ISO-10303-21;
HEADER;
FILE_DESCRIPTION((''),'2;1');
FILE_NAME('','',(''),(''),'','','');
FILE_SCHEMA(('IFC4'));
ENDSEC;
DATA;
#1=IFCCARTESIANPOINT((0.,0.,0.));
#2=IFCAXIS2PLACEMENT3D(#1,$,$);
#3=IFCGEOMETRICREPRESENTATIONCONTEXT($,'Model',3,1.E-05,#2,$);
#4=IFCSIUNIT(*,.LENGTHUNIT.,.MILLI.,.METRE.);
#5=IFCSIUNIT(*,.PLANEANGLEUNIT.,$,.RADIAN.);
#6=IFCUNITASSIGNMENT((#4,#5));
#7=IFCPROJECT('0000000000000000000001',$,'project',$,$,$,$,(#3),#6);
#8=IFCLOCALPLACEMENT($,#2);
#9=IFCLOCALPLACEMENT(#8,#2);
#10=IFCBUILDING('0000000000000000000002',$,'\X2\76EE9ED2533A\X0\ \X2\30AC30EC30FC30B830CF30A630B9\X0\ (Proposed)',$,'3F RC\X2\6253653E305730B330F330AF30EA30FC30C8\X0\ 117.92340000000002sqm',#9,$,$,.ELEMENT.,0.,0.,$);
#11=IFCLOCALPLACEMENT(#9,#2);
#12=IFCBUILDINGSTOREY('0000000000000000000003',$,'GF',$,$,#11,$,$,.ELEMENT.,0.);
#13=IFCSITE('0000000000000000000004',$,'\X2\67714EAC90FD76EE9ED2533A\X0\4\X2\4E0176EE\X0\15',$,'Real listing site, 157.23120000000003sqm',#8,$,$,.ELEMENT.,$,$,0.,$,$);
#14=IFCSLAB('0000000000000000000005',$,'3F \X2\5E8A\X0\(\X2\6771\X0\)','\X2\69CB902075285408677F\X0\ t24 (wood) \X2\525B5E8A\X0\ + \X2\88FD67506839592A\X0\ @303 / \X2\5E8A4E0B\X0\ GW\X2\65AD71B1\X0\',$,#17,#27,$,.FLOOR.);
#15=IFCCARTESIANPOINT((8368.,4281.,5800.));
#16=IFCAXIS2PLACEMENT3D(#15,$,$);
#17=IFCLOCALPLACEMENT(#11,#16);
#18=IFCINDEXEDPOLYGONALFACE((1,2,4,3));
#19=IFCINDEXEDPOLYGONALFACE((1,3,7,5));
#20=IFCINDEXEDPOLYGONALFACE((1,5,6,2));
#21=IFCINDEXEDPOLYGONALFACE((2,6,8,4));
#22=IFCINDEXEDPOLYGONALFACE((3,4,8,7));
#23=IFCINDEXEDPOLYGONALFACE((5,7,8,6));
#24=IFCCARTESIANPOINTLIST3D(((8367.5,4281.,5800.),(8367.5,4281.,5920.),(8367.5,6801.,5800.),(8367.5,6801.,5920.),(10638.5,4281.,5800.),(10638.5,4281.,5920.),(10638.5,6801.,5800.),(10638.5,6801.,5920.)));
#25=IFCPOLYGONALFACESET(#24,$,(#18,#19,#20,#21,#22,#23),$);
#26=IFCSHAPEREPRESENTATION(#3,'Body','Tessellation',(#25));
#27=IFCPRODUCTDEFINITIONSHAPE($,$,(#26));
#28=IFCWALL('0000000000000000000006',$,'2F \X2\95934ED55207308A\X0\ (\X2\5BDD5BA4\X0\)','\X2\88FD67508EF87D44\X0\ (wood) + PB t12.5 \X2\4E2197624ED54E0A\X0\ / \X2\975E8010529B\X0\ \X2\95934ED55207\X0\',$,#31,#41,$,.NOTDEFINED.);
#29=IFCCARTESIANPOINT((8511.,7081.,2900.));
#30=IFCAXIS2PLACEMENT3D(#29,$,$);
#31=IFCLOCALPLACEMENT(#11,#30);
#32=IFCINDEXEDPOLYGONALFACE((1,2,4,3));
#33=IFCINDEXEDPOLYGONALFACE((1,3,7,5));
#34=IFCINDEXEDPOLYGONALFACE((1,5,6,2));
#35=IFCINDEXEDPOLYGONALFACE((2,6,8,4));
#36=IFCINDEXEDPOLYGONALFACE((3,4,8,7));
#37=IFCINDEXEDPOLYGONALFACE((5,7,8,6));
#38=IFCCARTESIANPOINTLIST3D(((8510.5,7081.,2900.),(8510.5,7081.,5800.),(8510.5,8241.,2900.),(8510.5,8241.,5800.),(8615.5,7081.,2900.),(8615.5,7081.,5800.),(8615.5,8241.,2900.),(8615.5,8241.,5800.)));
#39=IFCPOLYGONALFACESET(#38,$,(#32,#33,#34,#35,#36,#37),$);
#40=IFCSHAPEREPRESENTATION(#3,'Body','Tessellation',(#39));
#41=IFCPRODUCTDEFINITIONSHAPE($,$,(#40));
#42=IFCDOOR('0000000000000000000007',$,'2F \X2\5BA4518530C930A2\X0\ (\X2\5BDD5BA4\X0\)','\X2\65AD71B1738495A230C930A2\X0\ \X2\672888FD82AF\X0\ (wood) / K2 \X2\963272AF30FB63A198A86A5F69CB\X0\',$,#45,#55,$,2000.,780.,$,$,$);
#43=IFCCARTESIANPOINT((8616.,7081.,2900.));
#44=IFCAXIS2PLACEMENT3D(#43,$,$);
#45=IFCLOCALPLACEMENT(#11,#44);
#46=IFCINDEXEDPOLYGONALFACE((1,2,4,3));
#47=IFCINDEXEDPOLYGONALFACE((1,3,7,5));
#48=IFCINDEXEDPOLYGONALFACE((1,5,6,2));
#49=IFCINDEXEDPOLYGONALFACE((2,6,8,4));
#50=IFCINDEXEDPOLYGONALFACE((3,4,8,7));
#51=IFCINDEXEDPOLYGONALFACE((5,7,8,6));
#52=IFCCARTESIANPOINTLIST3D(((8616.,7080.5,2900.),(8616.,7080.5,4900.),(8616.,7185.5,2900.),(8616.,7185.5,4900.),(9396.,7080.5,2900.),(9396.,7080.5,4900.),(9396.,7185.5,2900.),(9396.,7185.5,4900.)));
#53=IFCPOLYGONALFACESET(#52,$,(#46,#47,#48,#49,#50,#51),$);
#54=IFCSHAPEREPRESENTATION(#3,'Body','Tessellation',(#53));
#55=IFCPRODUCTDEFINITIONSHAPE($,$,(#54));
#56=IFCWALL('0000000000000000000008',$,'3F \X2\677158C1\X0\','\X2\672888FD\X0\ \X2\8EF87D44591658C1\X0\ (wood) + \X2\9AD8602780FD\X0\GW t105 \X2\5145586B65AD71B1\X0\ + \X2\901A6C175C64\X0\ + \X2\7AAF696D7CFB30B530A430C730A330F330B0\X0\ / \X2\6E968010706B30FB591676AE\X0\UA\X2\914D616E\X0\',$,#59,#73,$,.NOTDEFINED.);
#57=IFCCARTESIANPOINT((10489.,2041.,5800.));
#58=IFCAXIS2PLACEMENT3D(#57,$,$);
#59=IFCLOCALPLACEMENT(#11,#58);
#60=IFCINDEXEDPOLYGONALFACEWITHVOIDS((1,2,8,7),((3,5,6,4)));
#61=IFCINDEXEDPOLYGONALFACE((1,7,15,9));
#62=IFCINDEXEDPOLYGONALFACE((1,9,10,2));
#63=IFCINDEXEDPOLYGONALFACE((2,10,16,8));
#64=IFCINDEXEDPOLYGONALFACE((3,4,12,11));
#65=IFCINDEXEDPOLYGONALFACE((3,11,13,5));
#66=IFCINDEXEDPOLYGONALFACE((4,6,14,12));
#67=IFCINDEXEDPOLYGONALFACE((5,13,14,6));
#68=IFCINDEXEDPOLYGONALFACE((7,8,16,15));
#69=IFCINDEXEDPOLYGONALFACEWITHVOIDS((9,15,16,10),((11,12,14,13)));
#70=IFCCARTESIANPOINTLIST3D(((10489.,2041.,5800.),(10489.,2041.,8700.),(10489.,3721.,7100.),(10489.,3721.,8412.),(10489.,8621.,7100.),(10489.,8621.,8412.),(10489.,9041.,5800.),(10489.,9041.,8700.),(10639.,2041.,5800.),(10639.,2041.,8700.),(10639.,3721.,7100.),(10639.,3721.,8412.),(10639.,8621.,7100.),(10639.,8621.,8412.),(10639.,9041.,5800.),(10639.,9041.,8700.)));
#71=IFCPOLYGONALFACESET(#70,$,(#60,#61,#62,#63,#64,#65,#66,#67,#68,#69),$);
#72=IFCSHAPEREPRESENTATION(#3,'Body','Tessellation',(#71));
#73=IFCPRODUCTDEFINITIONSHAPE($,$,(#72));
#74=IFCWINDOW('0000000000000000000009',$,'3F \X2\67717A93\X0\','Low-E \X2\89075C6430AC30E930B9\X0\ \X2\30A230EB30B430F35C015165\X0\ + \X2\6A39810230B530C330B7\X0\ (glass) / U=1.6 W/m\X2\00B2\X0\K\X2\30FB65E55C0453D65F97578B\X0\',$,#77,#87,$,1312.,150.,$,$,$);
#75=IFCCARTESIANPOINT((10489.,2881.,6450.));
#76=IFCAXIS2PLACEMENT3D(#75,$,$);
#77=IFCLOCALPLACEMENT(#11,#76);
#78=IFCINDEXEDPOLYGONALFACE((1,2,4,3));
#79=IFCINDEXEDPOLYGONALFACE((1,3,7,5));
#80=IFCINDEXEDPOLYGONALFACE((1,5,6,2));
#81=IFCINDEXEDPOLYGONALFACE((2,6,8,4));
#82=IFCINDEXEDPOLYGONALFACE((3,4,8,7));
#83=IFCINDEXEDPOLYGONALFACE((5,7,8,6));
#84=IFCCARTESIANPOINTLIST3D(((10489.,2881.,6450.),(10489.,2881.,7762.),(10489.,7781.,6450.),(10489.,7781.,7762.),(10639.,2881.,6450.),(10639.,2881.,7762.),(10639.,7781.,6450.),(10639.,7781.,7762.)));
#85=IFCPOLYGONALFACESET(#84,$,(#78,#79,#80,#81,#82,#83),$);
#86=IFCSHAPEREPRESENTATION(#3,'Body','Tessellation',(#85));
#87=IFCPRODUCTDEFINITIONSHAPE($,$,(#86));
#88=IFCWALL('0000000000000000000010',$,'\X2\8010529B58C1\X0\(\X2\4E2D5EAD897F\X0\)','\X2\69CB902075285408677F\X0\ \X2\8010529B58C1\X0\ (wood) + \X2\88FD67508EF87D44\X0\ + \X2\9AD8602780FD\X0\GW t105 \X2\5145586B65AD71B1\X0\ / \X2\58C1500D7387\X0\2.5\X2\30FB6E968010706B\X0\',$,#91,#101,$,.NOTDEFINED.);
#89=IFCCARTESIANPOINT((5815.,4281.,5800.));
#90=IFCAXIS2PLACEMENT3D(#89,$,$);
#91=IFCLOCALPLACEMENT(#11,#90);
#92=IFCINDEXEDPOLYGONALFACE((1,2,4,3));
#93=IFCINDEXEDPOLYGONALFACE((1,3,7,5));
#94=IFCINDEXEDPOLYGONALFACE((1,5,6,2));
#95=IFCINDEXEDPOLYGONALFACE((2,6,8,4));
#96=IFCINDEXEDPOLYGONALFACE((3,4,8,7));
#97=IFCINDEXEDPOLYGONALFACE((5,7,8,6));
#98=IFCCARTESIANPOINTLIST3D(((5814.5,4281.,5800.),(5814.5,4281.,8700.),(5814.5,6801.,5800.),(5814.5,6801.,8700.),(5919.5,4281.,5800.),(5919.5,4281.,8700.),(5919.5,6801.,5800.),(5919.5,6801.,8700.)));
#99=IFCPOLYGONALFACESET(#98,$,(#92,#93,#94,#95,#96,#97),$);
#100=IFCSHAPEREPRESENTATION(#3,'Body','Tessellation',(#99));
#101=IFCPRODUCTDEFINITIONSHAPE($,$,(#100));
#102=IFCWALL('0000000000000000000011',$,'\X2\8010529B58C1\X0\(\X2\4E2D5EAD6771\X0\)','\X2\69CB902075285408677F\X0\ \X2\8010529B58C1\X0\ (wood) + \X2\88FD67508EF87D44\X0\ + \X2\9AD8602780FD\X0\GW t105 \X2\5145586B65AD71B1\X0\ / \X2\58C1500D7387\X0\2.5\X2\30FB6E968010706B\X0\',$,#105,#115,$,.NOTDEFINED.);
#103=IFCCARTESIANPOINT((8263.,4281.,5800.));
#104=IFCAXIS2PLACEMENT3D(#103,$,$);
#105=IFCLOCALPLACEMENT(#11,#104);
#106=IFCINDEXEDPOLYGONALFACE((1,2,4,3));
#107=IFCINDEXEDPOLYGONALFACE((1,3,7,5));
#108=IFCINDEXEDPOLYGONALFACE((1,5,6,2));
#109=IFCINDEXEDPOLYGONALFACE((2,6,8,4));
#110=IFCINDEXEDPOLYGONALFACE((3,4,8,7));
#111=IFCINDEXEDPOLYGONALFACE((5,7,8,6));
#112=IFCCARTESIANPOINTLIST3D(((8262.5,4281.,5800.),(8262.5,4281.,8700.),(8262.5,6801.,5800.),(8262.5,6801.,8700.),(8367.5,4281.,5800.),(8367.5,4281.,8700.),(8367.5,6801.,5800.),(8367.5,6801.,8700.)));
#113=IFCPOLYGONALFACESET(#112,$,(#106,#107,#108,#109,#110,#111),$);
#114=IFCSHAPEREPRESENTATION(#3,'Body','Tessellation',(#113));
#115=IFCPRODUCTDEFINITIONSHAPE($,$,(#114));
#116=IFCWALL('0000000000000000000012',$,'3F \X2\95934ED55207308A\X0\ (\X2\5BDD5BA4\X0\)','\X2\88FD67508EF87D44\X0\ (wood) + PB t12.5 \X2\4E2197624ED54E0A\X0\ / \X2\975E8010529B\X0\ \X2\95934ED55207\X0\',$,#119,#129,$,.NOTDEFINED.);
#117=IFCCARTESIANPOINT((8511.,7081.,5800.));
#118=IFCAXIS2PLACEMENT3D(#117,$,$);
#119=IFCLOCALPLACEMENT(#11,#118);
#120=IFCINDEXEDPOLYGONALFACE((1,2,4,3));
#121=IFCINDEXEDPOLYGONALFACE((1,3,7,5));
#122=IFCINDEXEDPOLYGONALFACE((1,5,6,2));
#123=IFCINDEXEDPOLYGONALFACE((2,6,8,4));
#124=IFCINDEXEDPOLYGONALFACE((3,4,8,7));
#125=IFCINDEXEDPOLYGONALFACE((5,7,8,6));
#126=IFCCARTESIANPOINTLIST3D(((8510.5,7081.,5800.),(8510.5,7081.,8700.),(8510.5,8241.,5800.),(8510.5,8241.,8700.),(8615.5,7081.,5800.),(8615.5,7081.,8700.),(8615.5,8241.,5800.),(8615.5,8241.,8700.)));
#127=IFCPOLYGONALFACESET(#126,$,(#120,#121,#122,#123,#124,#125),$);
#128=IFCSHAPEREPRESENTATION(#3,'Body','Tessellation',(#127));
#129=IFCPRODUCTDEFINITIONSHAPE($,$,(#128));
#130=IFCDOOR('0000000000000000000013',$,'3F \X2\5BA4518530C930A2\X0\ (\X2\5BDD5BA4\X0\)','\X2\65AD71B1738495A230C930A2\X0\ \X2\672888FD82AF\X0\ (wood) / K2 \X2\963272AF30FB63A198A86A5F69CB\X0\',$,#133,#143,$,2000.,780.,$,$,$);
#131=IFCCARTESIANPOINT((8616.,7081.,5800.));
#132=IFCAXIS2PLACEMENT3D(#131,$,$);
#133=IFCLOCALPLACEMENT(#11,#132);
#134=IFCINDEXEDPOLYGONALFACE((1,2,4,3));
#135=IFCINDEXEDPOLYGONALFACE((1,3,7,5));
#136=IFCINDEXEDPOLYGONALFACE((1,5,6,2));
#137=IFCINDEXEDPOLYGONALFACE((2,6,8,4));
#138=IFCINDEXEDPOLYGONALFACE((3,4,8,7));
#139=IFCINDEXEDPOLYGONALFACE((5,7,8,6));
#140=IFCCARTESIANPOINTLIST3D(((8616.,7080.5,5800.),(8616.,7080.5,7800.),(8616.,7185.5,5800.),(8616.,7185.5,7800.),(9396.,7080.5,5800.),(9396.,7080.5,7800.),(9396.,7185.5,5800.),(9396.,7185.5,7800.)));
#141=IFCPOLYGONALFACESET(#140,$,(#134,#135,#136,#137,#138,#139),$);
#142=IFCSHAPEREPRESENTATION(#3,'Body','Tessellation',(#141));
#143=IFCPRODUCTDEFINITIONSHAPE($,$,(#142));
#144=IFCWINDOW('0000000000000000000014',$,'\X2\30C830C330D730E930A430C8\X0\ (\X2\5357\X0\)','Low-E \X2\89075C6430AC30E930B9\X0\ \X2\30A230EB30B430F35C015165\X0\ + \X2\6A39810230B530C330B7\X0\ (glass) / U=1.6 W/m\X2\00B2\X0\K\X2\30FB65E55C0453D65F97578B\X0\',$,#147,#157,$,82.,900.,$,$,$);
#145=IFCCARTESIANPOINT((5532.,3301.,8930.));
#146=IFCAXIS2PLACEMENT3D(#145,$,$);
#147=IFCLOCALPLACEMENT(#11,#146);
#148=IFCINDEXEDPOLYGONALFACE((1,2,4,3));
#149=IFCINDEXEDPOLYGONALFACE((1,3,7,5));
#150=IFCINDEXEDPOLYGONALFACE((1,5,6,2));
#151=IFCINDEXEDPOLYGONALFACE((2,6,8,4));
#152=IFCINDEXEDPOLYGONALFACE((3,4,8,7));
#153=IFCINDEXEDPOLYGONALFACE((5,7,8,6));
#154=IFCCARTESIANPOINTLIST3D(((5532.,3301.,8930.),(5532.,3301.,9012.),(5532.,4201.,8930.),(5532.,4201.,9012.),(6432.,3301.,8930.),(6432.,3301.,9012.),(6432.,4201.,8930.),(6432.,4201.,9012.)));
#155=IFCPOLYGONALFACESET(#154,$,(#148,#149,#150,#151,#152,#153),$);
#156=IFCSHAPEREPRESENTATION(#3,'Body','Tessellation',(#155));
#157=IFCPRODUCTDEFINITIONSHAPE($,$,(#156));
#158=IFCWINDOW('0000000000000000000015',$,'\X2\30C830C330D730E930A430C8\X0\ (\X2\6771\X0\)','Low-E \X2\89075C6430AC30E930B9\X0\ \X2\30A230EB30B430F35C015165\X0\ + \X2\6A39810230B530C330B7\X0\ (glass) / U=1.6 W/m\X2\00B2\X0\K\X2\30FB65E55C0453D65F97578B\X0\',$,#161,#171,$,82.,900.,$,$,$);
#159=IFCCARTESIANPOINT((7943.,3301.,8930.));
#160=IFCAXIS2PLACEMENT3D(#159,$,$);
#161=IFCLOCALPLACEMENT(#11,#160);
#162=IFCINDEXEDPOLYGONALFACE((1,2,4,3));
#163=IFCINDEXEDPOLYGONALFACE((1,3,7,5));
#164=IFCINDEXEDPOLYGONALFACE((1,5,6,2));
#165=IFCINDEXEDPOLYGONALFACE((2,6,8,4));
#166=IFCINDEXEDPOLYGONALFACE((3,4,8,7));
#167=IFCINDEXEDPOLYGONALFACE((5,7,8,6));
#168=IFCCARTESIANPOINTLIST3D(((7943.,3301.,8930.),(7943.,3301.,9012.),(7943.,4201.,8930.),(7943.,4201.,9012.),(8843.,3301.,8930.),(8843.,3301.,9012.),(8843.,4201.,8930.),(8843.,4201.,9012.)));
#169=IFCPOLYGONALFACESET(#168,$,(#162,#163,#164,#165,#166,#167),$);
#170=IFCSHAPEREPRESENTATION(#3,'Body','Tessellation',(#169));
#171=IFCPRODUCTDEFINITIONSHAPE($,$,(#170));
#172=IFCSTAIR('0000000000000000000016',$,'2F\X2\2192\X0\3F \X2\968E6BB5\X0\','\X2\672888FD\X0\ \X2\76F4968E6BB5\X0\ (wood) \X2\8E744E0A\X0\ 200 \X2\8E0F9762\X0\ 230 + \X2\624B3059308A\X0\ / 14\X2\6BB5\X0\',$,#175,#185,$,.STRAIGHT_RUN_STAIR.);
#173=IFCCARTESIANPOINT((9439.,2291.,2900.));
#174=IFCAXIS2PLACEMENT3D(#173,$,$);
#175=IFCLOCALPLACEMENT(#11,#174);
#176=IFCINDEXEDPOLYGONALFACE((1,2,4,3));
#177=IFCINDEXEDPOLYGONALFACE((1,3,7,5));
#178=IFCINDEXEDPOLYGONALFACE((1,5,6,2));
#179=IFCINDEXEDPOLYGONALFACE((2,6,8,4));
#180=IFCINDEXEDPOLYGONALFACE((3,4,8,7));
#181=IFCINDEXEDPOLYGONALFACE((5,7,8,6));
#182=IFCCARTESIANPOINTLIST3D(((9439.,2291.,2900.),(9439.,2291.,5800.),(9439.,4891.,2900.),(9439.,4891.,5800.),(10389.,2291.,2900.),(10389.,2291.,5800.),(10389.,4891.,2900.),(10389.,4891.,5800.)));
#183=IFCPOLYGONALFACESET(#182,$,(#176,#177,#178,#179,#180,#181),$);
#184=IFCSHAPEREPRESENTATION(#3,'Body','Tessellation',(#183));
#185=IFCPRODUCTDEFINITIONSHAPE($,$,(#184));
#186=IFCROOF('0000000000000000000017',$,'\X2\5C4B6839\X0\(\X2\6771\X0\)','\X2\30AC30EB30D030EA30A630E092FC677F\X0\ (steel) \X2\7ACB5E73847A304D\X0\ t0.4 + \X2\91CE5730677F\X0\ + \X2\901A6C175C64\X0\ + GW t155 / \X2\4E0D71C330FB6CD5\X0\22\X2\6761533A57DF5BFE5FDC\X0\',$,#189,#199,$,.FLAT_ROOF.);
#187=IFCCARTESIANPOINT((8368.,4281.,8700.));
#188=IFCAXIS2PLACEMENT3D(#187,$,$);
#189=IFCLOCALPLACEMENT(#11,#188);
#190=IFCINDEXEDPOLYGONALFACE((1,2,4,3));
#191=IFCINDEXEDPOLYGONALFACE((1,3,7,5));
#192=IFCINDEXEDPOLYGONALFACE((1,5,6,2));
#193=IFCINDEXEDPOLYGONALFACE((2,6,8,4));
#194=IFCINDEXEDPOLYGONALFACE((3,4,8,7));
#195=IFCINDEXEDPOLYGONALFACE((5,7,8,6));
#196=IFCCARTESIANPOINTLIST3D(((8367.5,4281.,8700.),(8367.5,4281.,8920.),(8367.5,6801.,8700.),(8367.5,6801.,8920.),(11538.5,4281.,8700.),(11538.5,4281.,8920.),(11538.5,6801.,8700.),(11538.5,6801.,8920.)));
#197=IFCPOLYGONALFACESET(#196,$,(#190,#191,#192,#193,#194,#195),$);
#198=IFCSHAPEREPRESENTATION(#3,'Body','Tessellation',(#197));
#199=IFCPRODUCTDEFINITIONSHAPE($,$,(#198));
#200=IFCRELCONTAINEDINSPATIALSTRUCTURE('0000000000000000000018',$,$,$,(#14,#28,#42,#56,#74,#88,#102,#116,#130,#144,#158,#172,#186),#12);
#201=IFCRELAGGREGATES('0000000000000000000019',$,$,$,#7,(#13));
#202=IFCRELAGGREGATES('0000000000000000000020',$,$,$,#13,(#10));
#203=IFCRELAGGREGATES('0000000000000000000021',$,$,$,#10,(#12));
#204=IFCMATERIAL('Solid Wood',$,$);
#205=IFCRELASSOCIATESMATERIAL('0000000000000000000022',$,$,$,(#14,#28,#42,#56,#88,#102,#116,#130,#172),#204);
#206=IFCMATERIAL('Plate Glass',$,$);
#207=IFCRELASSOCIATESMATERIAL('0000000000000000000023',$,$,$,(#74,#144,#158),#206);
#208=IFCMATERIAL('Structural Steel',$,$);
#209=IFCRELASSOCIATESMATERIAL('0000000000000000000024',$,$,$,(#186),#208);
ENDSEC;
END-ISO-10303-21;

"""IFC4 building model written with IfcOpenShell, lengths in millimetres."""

from ifc_helpers import new_model, si_unit, frame, frame_2d, origin, place, context, project, spatial, rectangle, extrude, material, element, fill, save


model = new_model("IFC4")

# Units and contexts
model_context = context("Model", 3, precision=1e-05, world=origin())
ifc_project = project(units=[si_unit("LENGTHUNIT", "METRE", prefix="MILLI"), si_unit("PLANEANGLEUNIT", "RADIAN")], contexts=[model_context])

# Site, building, storey
site_placement = place(None, origin())
site = spatial("IfcSite", under=ifc_project, at=site_placement, Name="東京都目黒区4丁目15", ObjectType="Real listing site, 157.23120000000003sqm", CompositionType="ELEMENT", RefElevation=0.0)
building_placement = place(site_placement, origin())
building = spatial("IfcBuilding", under=site, at=building_placement, Name="目黒区 ガレージハウス (Proposed)", ObjectType="3F RC打放しコンクリート 117.92340000000002sqm", CompositionType="ELEMENT", ElevationOfRefHeight=0.0, ElevationOfTerrain=0.0)
storey_placement = place(building_placement, origin())
storey = spatial("IfcBuildingStorey", under=building, at=storey_placement, Name="GF", CompositionType="ELEMENT", Elevation=0.0)

# Slab
ifc_material_1 = material(Name="Solid Wood")
slab_placement = place(storey_placement, frame((8368.0, 4281.0, 5800.0)))
element("IfcSlab", 1, at=slab_placement, inside=storey, material=ifc_material_1, Name="3F 床(東)", Description="構造用合板 t24 (wood) 剛床 + 製材根太 @303 / 床下 GW断熱", PredefinedType="FLOOR", context=model_context, shape_type="SweptSolid", body=[
    extrude(rectangle(XDim=2271.0, YDim=2520.0, at=frame_2d((1135.0, 1260.0))), frame((8368.0, 4281.0, 5800.0)), (0.0, 0.0, 1.0), 120.0),
])

# Wall
wall_1_placement = place(storey_placement, frame((8511.0, 7081.0, 2900.0)))
element("IfcWall", 2, at=wall_1_placement, inside=storey, material=ifc_material_1, Name="2F 間仕切り (寝室)", Description="製材軸組 (wood) + PB t12.5 両面仕上 / 非耐力 間仕切", PredefinedType="NOTDEFINED", context=model_context, shape_type="SweptSolid", body=[
    extrude(rectangle(XDim=105.0, YDim=1160.0, at=frame_2d((52.0, 580.0))), frame((8511.0, 7081.0, 2900.0)), (0.0, 0.0, 1.0), 2900.0),
])

# Door
door_1_placement = place(storey_placement, frame((8616.0, 7081.0, 2900.0)))
element("IfcDoor", 3, at=door_1_placement, inside=storey, material=ifc_material_1, Name="2F 室内ドア (寝室)", Description="断熱玄関ドア 木製芯 (wood) / K2 防犯・採風機構", OverallHeight=2000.0, OverallWidth=780.0, context=model_context, shape_type="SweptSolid", body=[
    extrude(rectangle(XDim=780.0, YDim=105.0, at=frame_2d((390.0, 52.0))), frame((8616.0, 7081.0, 2900.0)), (0.0, 0.0, 1.0), 2000.0),
])

# Wall, opening, window
wall_2_placement = place(storey_placement, frame((10489.0, 2041.0, 5800.0)))
wall_2 = element("IfcWall", 4, at=wall_2_placement, inside=storey, material=ifc_material_1, Name="3F 東壁", Description="木製 軸組外壁 (wood) + 高性能GW t105 充填断熱 + 通気層 + 窯業系サイディング / 準耐火・外皮UA配慮", PredefinedType="NOTDEFINED", context=model_context, shape_type="SweptSolid", body=[
    extrude(rectangle(XDim=150.0, YDim=7000.0, at=frame_2d((75.0, 3500.0))), frame((10489.0, 2041.0, 5800.0)), (0.0, 0.0, 1.0), 2900.0),
])
opening_1_placement = place(storey_placement, frame((10489.0, 2881.0, 6450.0)))
opening_1 = element("IfcOpeningElement", 5, at=opening_1_placement, cuts=wall_2, PredefinedType="NOTDEFINED", context=model_context, shape_type="SweptSolid", body=[
    extrude(rectangle(XDim=150.0, YDim=4900.0, at=frame_2d((75.0, 2450.0))), frame((10489.0, 2881.0, 6450.0)), (0.0, 0.0, 1.0), 1312.0),
])
ifc_material_2 = material(Name="Plate Glass")
window_1_placement = place(storey_placement, frame((10489.0, 2881.0, 6450.0)))
window_1 = element("IfcWindow", 6, at=window_1_placement, inside=storey, material=ifc_material_2, Name="3F 東窓", Description="Low-E 複層ガラス アルゴン封入 + 樹脂サッシ (glass) / U=1.6 W/m²K・日射取得型", OverallHeight=1312.0, OverallWidth=150.0, context=model_context, shape_type="SweptSolid", body=[
    extrude(rectangle(XDim=150.0, YDim=4900.0, at=frame_2d((75.0, 2450.0))), frame((10489.0, 2881.0, 6450.0)), (0.0, 0.0, 1.0), 1312.0),
])
fill(opening_1, window_1)

# Walls
wall_3_placement = place(storey_placement, frame((5815.0, 4281.0, 5800.0)))
element("IfcWall", 7, at=wall_3_placement, inside=storey, material=ifc_material_1, Name="耐力壁(中庭西)", Description="構造用合板 耐力壁 (wood) + 製材軸組 + 高性能GW t105 充填断熱 / 壁倍率2.5・準耐火", PredefinedType="NOTDEFINED", context=model_context, shape_type="SweptSolid", body=[
    extrude(rectangle(XDim=105.0, YDim=2520.0, at=frame_2d((52.0, 1260.0))), frame((5815.0, 4281.0, 5800.0)), (0.0, 0.0, 1.0), 2900.0),
])
wall_4_placement = place(storey_placement, frame((8263.0, 4281.0, 5800.0)))
element("IfcWall", 8, at=wall_4_placement, inside=storey, material=ifc_material_1, Name="耐力壁(中庭東)", Description="構造用合板 耐力壁 (wood) + 製材軸組 + 高性能GW t105 充填断熱 / 壁倍率2.5・準耐火", PredefinedType="NOTDEFINED", context=model_context, shape_type="SweptSolid", body=[
    extrude(rectangle(XDim=105.0, YDim=2520.0, at=frame_2d((52.0, 1260.0))), frame((8263.0, 4281.0, 5800.0)), (0.0, 0.0, 1.0), 2900.0),
])
wall_5_placement = place(storey_placement, frame((8511.0, 7081.0, 5800.0)))
element("IfcWall", 9, at=wall_5_placement, inside=storey, material=ifc_material_1, Name="3F 間仕切り (寝室)", Description="製材軸組 (wood) + PB t12.5 両面仕上 / 非耐力 間仕切", PredefinedType="NOTDEFINED", context=model_context, shape_type="SweptSolid", body=[
    extrude(rectangle(XDim=105.0, YDim=1160.0, at=frame_2d((52.0, 580.0))), frame((8511.0, 7081.0, 5800.0)), (0.0, 0.0, 1.0), 2900.0),
])

# Door
door_2_placement = place(storey_placement, frame((8616.0, 7081.0, 5800.0)))
element("IfcDoor", 10, at=door_2_placement, inside=storey, material=ifc_material_1, Name="3F 室内ドア (寝室)", Description="断熱玄関ドア 木製芯 (wood) / K2 防犯・採風機構", OverallHeight=2000.0, OverallWidth=780.0, context=model_context, shape_type="SweptSolid", body=[
    extrude(rectangle(XDim=780.0, YDim=105.0, at=frame_2d((390.0, 52.0))), frame((8616.0, 7081.0, 5800.0)), (0.0, 0.0, 1.0), 2000.0),
])

# Windows
window_2_placement = place(storey_placement, frame((5532.0, 3301.0, 8930.0)))
element("IfcWindow", 11, at=window_2_placement, inside=storey, material=ifc_material_2, Name="トップライト (南)", Description="Low-E 複層ガラス アルゴン封入 + 樹脂サッシ (glass) / U=1.6 W/m²K・日射取得型", OverallHeight=82.0, OverallWidth=900.0, context=model_context, shape_type="SweptSolid", body=[
    extrude(rectangle(XDim=900.0, YDim=900.0, at=frame_2d((450.0, 450.0))), frame((5532.0, 3301.0, 8930.0)), (0.0, 0.0, 1.0), 82.0),
])
window_3_placement = place(storey_placement, frame((7943.0, 3301.0, 8930.0)))
element("IfcWindow", 12, at=window_3_placement, inside=storey, material=ifc_material_2, Name="トップライト (東)", Description="Low-E 複層ガラス アルゴン封入 + 樹脂サッシ (glass) / U=1.6 W/m²K・日射取得型", OverallHeight=82.0, OverallWidth=900.0, context=model_context, shape_type="SweptSolid", body=[
    extrude(rectangle(XDim=900.0, YDim=900.0, at=frame_2d((450.0, 450.0))), frame((7943.0, 3301.0, 8930.0)), (0.0, 0.0, 1.0), 82.0),
])

# Stair
stair_placement = place(storey_placement, frame((9439.0, 2291.0, 2900.0)))
element("IfcStair", 13, at=stair_placement, inside=storey, material=ifc_material_1, Name="2F→3F 階段", Description="木製 直階段 (wood) 蹴上 200 踏面 230 + 手すり / 14段", PredefinedType="STRAIGHT_RUN_STAIR", context=model_context, shape_type="SweptSolid", body=[
    extrude(rectangle(XDim=950.0, YDim=2600.0, at=frame_2d((475.0, 1300.0))), frame((9439.0, 2291.0, 2900.0)), (0.0, 0.0, 1.0), 2900.0),
])

# Roof
ifc_material_3 = material(Name="Structural Steel")
for number, where, name in (
    (14, (8368.0, 4281.0, 8700.0), "屋根(東)"),
):
    element("IfcRoof", number, at=place(storey_placement, frame(where)), inside=storey, material=ifc_material_3, Name=name, Description="ガルバリウム鋼板 (steel) 立平葺き t0.4 + 野地板 + 通気層 + GW t155 / 不燃・法22条区域対応", PredefinedType="FLAT_ROOF", context=model_context, shape_type="SweptSolid", body=[
        extrude(rectangle(XDim=3171.0, YDim=2520.0, at=frame_2d((1585.0, 1260.0))), frame((8368.0, 4281.0, 8700.0)), (0.0, 0.0, 1.0), 220.0),
    ])

save(model, "model.ifc")
